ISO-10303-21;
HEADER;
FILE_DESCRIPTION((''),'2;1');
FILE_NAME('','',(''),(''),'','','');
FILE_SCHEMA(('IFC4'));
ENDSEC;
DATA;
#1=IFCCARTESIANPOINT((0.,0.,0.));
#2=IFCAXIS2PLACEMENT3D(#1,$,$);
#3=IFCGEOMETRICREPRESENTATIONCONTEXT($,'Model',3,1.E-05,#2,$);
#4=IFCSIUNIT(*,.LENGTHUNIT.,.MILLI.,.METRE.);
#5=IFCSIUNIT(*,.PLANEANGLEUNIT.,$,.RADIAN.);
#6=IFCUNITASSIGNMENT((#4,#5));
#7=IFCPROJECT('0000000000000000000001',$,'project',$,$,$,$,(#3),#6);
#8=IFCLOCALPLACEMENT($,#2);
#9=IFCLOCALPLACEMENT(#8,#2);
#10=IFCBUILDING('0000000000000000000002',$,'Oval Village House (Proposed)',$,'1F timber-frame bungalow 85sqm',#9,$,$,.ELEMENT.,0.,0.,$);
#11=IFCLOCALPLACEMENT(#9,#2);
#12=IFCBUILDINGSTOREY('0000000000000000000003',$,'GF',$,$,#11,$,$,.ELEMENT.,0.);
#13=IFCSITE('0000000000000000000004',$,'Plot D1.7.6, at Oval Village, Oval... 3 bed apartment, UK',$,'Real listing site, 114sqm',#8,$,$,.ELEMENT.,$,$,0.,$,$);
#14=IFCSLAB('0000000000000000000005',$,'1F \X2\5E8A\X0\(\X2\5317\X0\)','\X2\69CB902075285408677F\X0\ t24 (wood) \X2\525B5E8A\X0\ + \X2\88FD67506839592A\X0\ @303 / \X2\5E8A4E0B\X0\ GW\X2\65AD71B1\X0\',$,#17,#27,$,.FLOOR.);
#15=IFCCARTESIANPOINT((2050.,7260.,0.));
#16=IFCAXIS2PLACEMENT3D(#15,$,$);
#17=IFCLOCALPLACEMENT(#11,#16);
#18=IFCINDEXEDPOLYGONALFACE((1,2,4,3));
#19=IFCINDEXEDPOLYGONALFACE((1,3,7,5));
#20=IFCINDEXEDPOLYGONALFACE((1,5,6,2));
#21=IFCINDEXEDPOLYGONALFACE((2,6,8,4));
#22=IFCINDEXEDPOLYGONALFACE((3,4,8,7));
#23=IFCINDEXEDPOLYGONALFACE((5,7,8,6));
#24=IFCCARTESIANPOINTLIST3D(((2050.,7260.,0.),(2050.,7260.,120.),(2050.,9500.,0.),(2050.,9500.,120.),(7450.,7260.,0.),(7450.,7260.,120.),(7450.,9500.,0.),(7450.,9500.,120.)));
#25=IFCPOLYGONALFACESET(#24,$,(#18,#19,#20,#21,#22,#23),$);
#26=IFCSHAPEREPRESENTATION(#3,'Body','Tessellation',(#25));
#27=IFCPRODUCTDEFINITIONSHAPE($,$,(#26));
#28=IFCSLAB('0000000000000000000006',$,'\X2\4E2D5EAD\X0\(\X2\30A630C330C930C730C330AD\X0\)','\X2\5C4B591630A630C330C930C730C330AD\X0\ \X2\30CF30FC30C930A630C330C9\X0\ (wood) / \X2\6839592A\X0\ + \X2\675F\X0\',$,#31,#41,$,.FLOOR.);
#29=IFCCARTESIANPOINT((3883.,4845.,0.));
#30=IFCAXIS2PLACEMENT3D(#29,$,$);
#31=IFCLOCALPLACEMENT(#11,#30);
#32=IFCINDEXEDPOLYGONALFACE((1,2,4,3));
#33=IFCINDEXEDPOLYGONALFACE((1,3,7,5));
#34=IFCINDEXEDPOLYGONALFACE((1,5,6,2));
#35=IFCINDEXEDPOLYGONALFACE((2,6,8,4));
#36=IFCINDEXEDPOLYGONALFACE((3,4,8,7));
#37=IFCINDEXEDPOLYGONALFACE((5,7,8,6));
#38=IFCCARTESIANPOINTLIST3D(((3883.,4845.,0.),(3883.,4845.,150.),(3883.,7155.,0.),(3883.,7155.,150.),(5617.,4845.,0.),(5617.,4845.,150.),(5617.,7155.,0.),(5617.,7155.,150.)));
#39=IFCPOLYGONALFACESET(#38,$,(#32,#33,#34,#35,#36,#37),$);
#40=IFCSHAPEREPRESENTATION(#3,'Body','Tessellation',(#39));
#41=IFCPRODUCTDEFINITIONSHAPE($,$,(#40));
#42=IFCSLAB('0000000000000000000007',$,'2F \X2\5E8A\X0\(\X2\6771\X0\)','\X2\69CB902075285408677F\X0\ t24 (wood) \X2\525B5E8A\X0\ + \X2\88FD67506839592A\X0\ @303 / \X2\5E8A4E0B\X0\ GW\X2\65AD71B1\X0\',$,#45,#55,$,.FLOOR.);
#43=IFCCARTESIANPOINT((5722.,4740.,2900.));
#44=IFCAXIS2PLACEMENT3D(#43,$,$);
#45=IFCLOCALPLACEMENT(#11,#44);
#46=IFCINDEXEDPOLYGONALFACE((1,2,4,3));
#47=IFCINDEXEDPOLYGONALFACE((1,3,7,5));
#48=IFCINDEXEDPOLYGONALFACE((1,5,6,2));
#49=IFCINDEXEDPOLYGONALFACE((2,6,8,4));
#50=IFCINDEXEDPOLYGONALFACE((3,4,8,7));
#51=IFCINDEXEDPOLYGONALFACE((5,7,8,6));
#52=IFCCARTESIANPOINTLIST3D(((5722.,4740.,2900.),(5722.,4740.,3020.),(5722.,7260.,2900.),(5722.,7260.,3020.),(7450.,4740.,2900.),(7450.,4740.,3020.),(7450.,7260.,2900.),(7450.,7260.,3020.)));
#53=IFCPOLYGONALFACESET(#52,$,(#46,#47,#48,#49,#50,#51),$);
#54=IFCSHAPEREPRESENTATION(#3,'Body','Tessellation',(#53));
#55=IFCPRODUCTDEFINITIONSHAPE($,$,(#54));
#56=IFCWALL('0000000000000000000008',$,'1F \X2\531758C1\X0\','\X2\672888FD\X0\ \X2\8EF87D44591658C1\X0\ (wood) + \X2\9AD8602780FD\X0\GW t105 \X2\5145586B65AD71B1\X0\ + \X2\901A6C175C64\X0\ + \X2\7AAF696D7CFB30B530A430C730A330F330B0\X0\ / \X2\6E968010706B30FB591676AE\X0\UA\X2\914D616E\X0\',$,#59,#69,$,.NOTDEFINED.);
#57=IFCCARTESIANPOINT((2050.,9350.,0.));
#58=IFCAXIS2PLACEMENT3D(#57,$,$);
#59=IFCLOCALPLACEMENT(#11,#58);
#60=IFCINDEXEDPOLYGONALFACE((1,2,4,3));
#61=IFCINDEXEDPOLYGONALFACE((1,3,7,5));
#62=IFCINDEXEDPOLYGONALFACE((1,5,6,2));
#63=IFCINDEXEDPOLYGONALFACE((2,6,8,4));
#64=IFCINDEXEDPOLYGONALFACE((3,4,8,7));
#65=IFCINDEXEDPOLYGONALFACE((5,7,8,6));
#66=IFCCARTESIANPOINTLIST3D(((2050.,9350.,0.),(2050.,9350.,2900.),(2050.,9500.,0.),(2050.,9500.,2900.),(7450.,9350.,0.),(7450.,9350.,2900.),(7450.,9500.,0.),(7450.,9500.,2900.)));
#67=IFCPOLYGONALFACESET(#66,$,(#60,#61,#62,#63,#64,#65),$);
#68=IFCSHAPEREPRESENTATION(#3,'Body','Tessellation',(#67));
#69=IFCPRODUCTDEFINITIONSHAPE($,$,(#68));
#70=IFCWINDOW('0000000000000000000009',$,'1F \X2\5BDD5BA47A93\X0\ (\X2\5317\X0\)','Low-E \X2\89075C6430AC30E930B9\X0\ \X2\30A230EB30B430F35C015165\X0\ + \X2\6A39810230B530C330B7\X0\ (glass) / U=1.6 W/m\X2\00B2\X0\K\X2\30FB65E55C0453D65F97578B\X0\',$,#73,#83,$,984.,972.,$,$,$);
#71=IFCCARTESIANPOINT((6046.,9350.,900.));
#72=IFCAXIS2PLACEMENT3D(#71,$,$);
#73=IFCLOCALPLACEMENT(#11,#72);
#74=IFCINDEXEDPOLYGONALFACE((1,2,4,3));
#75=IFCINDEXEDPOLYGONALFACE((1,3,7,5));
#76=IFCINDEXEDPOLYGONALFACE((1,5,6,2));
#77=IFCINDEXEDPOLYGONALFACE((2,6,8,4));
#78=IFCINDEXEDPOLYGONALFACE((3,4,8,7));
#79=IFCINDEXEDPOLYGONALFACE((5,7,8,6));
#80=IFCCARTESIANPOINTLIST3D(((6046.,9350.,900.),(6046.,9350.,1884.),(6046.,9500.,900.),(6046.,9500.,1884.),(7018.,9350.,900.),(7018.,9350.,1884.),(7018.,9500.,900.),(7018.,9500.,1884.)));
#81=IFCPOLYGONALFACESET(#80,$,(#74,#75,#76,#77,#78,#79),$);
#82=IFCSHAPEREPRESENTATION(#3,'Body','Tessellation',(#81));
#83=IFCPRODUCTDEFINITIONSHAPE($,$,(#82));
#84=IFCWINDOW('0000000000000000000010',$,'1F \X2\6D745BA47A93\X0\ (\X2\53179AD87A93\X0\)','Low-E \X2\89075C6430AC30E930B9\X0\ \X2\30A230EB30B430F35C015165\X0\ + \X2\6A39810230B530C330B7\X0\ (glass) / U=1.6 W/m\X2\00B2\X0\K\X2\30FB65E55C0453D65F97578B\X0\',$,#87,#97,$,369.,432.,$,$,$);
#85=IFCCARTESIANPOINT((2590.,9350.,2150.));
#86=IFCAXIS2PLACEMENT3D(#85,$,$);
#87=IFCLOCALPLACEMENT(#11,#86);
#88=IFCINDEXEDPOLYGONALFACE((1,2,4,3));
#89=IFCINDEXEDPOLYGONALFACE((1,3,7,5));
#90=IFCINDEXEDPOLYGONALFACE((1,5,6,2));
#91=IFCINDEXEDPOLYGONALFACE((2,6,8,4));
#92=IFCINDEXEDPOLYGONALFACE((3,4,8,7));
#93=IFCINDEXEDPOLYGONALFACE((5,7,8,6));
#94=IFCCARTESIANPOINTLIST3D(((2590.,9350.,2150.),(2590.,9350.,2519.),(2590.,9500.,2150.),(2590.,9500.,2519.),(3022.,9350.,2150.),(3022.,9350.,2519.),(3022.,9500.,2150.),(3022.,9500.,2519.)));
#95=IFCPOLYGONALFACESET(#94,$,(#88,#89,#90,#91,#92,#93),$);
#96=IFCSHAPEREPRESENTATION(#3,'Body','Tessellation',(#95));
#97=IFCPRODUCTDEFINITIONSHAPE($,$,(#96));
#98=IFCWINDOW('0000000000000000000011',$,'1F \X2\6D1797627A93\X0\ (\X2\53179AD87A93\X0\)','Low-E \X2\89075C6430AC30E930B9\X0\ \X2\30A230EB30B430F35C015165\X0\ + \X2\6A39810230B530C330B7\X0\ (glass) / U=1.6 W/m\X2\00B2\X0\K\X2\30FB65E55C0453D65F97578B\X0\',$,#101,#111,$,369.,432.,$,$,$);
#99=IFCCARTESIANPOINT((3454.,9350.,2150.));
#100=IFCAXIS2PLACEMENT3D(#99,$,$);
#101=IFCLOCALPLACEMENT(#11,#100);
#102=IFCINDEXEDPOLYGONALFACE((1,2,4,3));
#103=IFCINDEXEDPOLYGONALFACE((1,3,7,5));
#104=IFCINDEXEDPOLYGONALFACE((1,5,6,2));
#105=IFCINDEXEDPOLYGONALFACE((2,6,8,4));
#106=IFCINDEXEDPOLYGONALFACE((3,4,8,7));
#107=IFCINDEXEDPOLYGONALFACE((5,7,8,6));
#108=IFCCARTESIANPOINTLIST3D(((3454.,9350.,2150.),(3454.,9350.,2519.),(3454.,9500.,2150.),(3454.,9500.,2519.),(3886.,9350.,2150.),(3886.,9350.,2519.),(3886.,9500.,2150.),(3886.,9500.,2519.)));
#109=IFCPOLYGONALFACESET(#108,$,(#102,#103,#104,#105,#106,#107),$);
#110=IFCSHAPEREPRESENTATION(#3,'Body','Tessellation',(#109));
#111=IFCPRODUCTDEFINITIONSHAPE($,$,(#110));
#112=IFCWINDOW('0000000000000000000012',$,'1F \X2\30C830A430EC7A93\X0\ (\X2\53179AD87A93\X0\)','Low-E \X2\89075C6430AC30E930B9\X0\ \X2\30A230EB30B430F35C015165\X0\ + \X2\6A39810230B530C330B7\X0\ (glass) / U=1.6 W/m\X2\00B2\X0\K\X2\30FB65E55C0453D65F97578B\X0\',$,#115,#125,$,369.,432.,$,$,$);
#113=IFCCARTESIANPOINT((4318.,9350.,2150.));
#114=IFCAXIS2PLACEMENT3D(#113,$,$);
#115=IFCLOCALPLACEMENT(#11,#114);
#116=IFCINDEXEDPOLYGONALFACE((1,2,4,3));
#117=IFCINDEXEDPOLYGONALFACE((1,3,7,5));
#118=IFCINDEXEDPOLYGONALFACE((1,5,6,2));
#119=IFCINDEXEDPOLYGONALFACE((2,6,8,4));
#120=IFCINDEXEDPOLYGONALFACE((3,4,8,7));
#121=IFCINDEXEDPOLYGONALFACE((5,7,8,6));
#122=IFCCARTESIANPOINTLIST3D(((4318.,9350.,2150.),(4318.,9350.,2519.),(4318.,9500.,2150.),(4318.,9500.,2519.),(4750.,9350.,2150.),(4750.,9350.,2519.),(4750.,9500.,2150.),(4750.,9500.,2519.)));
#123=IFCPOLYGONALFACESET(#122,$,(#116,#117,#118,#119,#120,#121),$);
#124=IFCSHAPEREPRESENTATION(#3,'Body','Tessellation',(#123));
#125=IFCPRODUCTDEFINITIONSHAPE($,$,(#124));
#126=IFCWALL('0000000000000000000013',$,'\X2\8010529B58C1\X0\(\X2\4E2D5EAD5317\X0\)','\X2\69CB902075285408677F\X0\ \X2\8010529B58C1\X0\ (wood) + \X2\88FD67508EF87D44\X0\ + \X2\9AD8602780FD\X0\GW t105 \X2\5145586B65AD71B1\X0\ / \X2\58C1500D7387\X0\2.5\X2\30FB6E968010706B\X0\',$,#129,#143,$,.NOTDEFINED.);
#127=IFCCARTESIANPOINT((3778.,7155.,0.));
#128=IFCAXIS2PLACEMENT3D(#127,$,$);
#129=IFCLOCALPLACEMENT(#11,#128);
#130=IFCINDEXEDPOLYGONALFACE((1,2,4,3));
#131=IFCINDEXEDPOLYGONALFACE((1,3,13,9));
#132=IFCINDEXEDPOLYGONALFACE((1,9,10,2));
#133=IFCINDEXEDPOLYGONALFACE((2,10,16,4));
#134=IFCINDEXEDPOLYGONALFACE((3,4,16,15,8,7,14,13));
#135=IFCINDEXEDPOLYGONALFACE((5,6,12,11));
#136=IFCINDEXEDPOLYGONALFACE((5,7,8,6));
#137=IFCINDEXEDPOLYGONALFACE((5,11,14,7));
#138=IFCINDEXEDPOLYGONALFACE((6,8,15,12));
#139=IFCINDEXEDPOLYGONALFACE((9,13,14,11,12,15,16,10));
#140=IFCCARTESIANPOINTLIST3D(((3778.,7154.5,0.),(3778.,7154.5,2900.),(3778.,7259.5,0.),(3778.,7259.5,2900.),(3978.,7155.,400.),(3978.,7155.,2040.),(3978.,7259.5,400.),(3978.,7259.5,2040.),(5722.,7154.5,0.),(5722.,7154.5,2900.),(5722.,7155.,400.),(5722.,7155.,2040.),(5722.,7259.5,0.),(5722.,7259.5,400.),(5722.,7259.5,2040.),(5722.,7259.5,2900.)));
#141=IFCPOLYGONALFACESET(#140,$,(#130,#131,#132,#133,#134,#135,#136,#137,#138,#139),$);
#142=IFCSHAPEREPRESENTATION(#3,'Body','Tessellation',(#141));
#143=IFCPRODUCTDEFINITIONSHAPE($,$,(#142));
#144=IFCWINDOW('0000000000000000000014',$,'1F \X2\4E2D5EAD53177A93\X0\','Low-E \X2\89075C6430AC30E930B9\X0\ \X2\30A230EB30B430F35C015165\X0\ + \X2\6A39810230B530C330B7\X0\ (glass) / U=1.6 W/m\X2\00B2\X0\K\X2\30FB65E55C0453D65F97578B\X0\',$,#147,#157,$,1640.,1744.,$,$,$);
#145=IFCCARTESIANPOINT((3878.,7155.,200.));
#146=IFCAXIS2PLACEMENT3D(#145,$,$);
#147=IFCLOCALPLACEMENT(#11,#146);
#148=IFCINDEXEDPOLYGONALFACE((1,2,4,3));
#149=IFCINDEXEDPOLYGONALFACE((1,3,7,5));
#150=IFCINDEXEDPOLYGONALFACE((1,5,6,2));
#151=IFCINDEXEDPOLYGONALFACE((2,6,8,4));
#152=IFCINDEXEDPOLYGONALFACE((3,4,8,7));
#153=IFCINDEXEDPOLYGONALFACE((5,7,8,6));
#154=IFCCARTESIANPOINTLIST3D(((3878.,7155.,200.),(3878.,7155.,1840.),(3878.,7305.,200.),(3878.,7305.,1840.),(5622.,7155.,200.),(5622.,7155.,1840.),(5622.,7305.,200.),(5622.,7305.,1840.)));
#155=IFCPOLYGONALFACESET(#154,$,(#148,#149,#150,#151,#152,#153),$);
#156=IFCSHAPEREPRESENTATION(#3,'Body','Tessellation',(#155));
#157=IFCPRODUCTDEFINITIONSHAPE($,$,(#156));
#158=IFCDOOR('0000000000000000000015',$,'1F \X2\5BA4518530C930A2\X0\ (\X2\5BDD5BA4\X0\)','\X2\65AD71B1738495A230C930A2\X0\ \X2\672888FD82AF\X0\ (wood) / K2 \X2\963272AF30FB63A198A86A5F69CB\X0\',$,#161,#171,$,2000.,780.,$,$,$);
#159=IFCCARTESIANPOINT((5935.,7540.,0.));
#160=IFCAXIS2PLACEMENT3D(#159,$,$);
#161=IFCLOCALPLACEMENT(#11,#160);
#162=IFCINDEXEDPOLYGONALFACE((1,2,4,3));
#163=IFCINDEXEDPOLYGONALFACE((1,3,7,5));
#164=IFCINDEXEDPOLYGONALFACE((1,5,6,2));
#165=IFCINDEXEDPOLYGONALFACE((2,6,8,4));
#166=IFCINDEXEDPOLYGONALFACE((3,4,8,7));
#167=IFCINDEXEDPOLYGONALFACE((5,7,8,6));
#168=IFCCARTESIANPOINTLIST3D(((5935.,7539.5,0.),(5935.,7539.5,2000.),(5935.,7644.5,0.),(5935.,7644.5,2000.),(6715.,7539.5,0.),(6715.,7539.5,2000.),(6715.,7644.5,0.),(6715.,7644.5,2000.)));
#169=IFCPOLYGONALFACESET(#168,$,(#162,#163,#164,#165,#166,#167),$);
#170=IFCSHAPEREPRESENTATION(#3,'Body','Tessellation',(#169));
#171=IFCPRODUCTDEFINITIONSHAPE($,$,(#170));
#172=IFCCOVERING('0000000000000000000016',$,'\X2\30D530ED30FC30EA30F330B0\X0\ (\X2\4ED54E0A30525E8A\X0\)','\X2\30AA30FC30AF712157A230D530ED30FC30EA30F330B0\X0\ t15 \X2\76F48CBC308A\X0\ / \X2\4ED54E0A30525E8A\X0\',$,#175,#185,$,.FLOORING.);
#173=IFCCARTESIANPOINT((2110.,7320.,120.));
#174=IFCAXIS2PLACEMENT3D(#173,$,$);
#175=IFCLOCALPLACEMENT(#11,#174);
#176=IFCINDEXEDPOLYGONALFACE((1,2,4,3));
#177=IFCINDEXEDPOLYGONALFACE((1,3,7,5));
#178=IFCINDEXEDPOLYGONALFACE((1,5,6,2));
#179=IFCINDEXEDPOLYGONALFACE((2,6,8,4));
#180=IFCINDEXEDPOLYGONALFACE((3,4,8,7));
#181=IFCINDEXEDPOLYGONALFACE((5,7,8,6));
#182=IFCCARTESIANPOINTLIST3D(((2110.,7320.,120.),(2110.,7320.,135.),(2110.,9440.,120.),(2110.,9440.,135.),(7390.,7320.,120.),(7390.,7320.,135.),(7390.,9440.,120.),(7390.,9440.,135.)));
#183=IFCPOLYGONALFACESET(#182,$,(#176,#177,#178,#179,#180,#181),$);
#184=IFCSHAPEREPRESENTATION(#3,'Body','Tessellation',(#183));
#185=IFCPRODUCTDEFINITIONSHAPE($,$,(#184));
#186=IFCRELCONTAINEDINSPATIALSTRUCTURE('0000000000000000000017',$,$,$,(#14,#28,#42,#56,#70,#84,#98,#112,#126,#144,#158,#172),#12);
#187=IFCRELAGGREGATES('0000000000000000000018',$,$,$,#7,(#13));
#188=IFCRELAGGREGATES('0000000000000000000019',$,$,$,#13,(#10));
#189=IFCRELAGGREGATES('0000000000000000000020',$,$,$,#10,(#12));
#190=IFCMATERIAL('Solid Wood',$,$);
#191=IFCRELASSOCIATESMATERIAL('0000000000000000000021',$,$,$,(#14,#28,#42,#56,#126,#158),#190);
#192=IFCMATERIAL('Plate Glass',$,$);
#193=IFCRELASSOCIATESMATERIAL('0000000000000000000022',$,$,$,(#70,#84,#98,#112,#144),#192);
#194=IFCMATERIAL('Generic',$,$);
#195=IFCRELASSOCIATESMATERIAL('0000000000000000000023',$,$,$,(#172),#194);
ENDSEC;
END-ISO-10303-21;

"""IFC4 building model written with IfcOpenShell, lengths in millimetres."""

from ifc_helpers import new_model, si_unit, frame, frame_2d, origin, place, context, project, spatial, rectangle, extrude, material, element, fill, save


model = new_model("IFC4")

# Units and contexts
model_context = context("Model", 3, precision=1e-05, world=origin())
ifc_project = project(units=[si_unit("LENGTHUNIT", "METRE", prefix="MILLI"), si_unit("PLANEANGLEUNIT", "RADIAN")], contexts=[model_context])

# Site, building, storey
site_placement = place(None, origin())
site = spatial("IfcSite", under=ifc_project, at=site_placement, Name="Plot D1.7.6, at Oval Village, Oval... 3 bed apartment, UK", ObjectType="Real listing site, 114sqm", CompositionType="ELEMENT", RefElevation=0.0)
building_placement = place(site_placement, origin())
building = spatial("IfcBuilding", under=site, at=building_placement, Name="Oval Village House (Proposed)", ObjectType="1F timber-frame bungalow 85sqm", CompositionType="ELEMENT", ElevationOfRefHeight=0.0, ElevationOfTerrain=0.0)
storey_placement = place(building_placement, origin())
storey = spatial("IfcBuildingStorey", under=building, at=storey_placement, Name="GF", CompositionType="ELEMENT", Elevation=0.0)

# Slabs
ifc_material_1 = material(Name="Solid Wood")
slab_1_placement = place(storey_placement, frame((2050.0, 7260.0, 0.0)))
element("IfcSlab", 1, at=slab_1_placement, inside=storey, material=ifc_material_1, Name="1F 床(北)", Description="構造用合板 t24 (wood) 剛床 + 製材根太 @303 / 床下 GW断熱", PredefinedType="FLOOR", context=model_context, shape_type="SweptSolid", body=[
    extrude(rectangle(XDim=5400.0, YDim=2240.0, at=frame_2d((2700.0, 1120.0))), frame((2050.0, 7260.0, 0.0)), (0.0, 0.0, 1.0), 120.0),
])
slab_2_placement = place(storey_placement, frame((3883.0, 4845.0, 0.0)))
element("IfcSlab", 2, at=slab_2_placement, inside=storey, material=ifc_material_1, Name="中庭(ウッドデッキ)", Description="屋外ウッドデッキ ハードウッド (wood) / 根太 + 束", PredefinedType="FLOOR", context=model_context, shape_type="SweptSolid", body=[
    extrude(rectangle(XDim=1734.0, YDim=2310.0, at=frame_2d((867.0, 1155.0))), frame((3883.0, 4845.0, 0.0)), (0.0, 0.0, 1.0), 150.0),
])
slab_3_placement = place(storey_placement, frame((5722.0, 4740.0, 2900.0)))
element("IfcSlab", 3, at=slab_3_placement, inside=storey, material=ifc_material_1, Name="2F 床(東)", Description="構造用合板 t24 (wood) 剛床 + 製材根太 @303 / 床下 GW断熱", PredefinedType="FLOOR", context=model_context, shape_type="SweptSolid", body=[
    extrude(rectangle(XDim=1728.0, YDim=2520.0, at=frame_2d((864.0, 1260.0))), frame((5722.0, 4740.0, 2900.0)), (0.0, 0.0, 1.0), 120.0),
])

# Wall, openings, windows
wall_1_placement = place(storey_placement, frame((2050.0, 9350.0, 0.0)))
wall_1 = element("IfcWall", 4, at=wall_1_placement, inside=storey, material=ifc_material_1, Name="1F 北壁", Description="木製 軸組外壁 (wood) + 高性能GW t105 充填断熱 + 通気層 + 窯業系サイディング / 準耐火・外皮UA配慮", PredefinedType="NOTDEFINED", context=model_context, shape_type="SweptSolid", body=[
    extrude(rectangle(XDim=5400.0, YDim=150.0, at=frame_2d((2700.0, 75.0))), frame((2050.0, 9350.0, 0.0)), (0.0, 0.0, 1.0), 2900.0),
])
opening_1_placement = place(storey_placement, frame((6046.0, 9350.0, 900.0)))
opening_1 = element("IfcOpeningElement", 5, at=opening_1_placement, cuts=wall_1, PredefinedType="NOTDEFINED", context=model_context, shape_type="SweptSolid", body=[
    extrude(rectangle(XDim=972.0, YDim=150.0, at=frame_2d((486.0, 75.0))), frame((6046.0, 9350.0, 900.0)), (0.0, 0.0, 1.0), 984.0),
])
opening_2_placement = place(storey_placement, frame((2590.0, 9350.0, 2150.0)))
opening_2 = element("IfcOpeningElement", 6, at=opening_2_placement, cuts=wall_1, PredefinedType="NOTDEFINED", context=model_context, shape_type="SweptSolid", body=[
    extrude(rectangle(XDim=432.0, YDim=150.0, at=frame_2d((216.0, 75.0))), frame((2590.0, 9350.0, 2150.0)), (0.0, 0.0, 1.0), 369.0),
])
opening_3_placement = place(storey_placement, frame((3454.0, 9350.0, 2150.0)))
opening_3 = element("IfcOpeningElement", 7, at=opening_3_placement, cuts=wall_1, PredefinedType="NOTDEFINED", context=model_context, shape_type="SweptSolid", body=[
    extrude(rectangle(XDim=432.0, YDim=150.0, at=frame_2d((216.0, 75.0))), frame((3454.0, 9350.0, 2150.0)), (0.0, 0.0, 1.0), 369.0),
])
opening_4_placement = place(storey_placement, frame((4318.0, 9350.0, 2150.0)))
opening_4 = element("IfcOpeningElement", 8, at=opening_4_placement, cuts=wall_1, PredefinedType="NOTDEFINED", context=model_context, shape_type="SweptSolid", body=[
    extrude(rectangle(XDim=432.0, YDim=150.0, at=frame_2d((216.0, 75.0))), frame((4318.0, 9350.0, 2150.0)), (0.0, 0.0, 1.0), 369.0),
])
ifc_material_2 = material(Name="Plate Glass")
window_1_placement = place(storey_placement, frame((6046.0, 9350.0, 900.0)))
window_1 = element("IfcWindow", 9, at=window_1_placement, inside=storey, material=ifc_material_2, Name="1F 寝室窓 (北)", Description="Low-E 複層ガラス アルゴン封入 + 樹脂サッシ (glass) / U=1.6 W/m²K・日射取得型", OverallHeight=984.0, OverallWidth=972.0, context=model_context, shape_type="SweptSolid", body=[
    extrude(rectangle(XDim=972.0, YDim=150.0, at=frame_2d((486.0, 75.0))), frame((6046.0, 9350.0, 900.0)), (0.0, 0.0, 1.0), 984.0),
])
fill(opening_1, window_1)
window_2_placement = place(storey_placement, frame((2590.0, 9350.0, 2150.0)))
window_2 = element("IfcWindow", 10, at=window_2_placement, inside=storey, material=ifc_material_2, Name="1F 浴室窓 (北高窓)", Description="Low-E 複層ガラス アルゴン封入 + 樹脂サッシ (glass) / U=1.6 W/m²K・日射取得型", OverallHeight=369.0, OverallWidth=432.0, context=model_context, shape_type="SweptSolid", body=[
    extrude(rectangle(XDim=432.0, YDim=150.0, at=frame_2d((216.0, 75.0))), frame((2590.0, 9350.0, 2150.0)), (0.0, 0.0, 1.0), 369.0),
])
fill(opening_2, window_2)
window_3_placement = place(storey_placement, frame((3454.0, 9350.0, 2150.0)))
window_3 = element("IfcWindow", 11, at=window_3_placement, inside=storey, material=ifc_material_2, Name="1F 洗面窓 (北高窓)", Description="Low-E 複層ガラス アルゴン封入 + 樹脂サッシ (glass) / U=1.6 W/m²K・日射取得型", OverallHeight=369.0, OverallWidth=432.0, context=model_context, shape_type="SweptSolid", body=[
    extrude(rectangle(XDim=432.0, YDim=150.0, at=frame_2d((216.0, 75.0))), frame((3454.0, 9350.0, 2150.0)), (0.0, 0.0, 1.0), 369.0),
])
fill(opening_3, window_3)
window_4_placement = place(storey_placement, frame((4318.0, 9350.0, 2150.0)))
window_4 = element("IfcWindow", 12, at=window_4_placement, inside=storey, material=ifc_material_2, Name="1F トイレ窓 (北高窓)", Description="Low-E 複層ガラス アルゴン封入 + 樹脂サッシ (glass) / U=1.6 W/m²K・日射取得型", OverallHeight=369.0, OverallWidth=432.0, context=model_context, shape_type="SweptSolid", body=[
    extrude(rectangle(XDim=432.0, YDim=150.0, at=frame_2d((216.0, 75.0))), frame((4318.0, 9350.0, 2150.0)), (0.0, 0.0, 1.0), 369.0),
])
fill(opening_4, window_4)

# Wall, opening, window
wall_2_placement = place(storey_placement, frame((3778.0, 7155.0, 0.0)))
wall_2 = element("IfcWall", 13, at=wall_2_placement, inside=storey, material=ifc_material_1, Name="耐力壁(中庭北)", Description="構造用合板 耐力壁 (wood) + 製材軸組 + 高性能GW t105 充填断熱 / 壁倍率2.5・準耐火", PredefinedType="NOTDEFINED", context=model_context, shape_type="SweptSolid", body=[
    extrude(rectangle(XDim=1944.0, YDim=105.0, at=frame_2d((972.0, 52.0))), frame((3778.0, 7155.0, 0.0)), (0.0, 0.0, 1.0), 2900.0),
])
opening_5_placement = place(storey_placement, frame((3878.0, 7155.0, 200.0)))
opening_5 = element("IfcOpeningElement", 14, at=opening_5_placement, cuts=wall_2, PredefinedType="NOTDEFINED", context=model_context, shape_type="SweptSolid", body=[
    extrude(rectangle(XDim=1744.0, YDim=150.0, at=frame_2d((872.0, 75.0))), frame((3878.0, 7155.0, 200.0)), (0.0, 0.0, 1.0), 1640.0),
])
window_5_placement = place(storey_placement, frame((3878.0, 7155.0, 200.0)))
window_5 = element("IfcWindow", 15, at=window_5_placement, inside=storey, material=ifc_material_2, Name="1F 中庭北窓", Description="Low-E 複層ガラス アルゴン封入 + 樹脂サッシ (glass) / U=1.6 W/m²K・日射取得型", OverallHeight=1640.0, OverallWidth=1744.0, context=model_context, shape_type="SweptSolid", body=[
    extrude(rectangle(XDim=1744.0, YDim=150.0, at=frame_2d((872.0, 75.0))), frame((3878.0, 7155.0, 200.0)), (0.0, 0.0, 1.0), 1640.0),
])
fill(opening_5, window_5)

# Door
door_1_placement = place(storey_placement, frame((5935.0, 7540.0, 0.0)))
element("IfcDoor", 16, at=door_1_placement, inside=storey, material=ifc_material_1, Name="1F 室内ドア (寝室)", Description="断熱玄関ドア 木製芯 (wood) / K2 防犯・採風機構", OverallHeight=2000.0, OverallWidth=780.0, context=model_context, shape_type="SweptSolid", body=[
    extrude(rectangle(XDim=780.0, YDim=105.0, at=frame_2d((390.0, 52.0))), frame((5935.0, 7540.0, 0.0)), (0.0, 0.0, 1.0), 2000.0),
])

# Covering
ifc_material_3 = material(Name="Generic")
covering_1_placement = place(storey_placement, frame((2110.0, 7320.0, 120.0)))
element("IfcCovering", 17, at=covering_1_placement, inside=storey, material=ifc_material_3, Name="フローリング (仕上げ床)", Description="オーク無垢フローリング t15 直貼り / 仕上げ床", PredefinedType="FLOORING", context=model_context, shape_type="SweptSolid", body=[
    extrude(rectangle(XDim=5280.0, YDim=2120.0, at=frame_2d((2640.0, 1060.0))), frame((2110.0, 7320.0, 120.0)), (0.0, 0.0, 1.0), 15.0),
])

save(model, "model.ifc")
